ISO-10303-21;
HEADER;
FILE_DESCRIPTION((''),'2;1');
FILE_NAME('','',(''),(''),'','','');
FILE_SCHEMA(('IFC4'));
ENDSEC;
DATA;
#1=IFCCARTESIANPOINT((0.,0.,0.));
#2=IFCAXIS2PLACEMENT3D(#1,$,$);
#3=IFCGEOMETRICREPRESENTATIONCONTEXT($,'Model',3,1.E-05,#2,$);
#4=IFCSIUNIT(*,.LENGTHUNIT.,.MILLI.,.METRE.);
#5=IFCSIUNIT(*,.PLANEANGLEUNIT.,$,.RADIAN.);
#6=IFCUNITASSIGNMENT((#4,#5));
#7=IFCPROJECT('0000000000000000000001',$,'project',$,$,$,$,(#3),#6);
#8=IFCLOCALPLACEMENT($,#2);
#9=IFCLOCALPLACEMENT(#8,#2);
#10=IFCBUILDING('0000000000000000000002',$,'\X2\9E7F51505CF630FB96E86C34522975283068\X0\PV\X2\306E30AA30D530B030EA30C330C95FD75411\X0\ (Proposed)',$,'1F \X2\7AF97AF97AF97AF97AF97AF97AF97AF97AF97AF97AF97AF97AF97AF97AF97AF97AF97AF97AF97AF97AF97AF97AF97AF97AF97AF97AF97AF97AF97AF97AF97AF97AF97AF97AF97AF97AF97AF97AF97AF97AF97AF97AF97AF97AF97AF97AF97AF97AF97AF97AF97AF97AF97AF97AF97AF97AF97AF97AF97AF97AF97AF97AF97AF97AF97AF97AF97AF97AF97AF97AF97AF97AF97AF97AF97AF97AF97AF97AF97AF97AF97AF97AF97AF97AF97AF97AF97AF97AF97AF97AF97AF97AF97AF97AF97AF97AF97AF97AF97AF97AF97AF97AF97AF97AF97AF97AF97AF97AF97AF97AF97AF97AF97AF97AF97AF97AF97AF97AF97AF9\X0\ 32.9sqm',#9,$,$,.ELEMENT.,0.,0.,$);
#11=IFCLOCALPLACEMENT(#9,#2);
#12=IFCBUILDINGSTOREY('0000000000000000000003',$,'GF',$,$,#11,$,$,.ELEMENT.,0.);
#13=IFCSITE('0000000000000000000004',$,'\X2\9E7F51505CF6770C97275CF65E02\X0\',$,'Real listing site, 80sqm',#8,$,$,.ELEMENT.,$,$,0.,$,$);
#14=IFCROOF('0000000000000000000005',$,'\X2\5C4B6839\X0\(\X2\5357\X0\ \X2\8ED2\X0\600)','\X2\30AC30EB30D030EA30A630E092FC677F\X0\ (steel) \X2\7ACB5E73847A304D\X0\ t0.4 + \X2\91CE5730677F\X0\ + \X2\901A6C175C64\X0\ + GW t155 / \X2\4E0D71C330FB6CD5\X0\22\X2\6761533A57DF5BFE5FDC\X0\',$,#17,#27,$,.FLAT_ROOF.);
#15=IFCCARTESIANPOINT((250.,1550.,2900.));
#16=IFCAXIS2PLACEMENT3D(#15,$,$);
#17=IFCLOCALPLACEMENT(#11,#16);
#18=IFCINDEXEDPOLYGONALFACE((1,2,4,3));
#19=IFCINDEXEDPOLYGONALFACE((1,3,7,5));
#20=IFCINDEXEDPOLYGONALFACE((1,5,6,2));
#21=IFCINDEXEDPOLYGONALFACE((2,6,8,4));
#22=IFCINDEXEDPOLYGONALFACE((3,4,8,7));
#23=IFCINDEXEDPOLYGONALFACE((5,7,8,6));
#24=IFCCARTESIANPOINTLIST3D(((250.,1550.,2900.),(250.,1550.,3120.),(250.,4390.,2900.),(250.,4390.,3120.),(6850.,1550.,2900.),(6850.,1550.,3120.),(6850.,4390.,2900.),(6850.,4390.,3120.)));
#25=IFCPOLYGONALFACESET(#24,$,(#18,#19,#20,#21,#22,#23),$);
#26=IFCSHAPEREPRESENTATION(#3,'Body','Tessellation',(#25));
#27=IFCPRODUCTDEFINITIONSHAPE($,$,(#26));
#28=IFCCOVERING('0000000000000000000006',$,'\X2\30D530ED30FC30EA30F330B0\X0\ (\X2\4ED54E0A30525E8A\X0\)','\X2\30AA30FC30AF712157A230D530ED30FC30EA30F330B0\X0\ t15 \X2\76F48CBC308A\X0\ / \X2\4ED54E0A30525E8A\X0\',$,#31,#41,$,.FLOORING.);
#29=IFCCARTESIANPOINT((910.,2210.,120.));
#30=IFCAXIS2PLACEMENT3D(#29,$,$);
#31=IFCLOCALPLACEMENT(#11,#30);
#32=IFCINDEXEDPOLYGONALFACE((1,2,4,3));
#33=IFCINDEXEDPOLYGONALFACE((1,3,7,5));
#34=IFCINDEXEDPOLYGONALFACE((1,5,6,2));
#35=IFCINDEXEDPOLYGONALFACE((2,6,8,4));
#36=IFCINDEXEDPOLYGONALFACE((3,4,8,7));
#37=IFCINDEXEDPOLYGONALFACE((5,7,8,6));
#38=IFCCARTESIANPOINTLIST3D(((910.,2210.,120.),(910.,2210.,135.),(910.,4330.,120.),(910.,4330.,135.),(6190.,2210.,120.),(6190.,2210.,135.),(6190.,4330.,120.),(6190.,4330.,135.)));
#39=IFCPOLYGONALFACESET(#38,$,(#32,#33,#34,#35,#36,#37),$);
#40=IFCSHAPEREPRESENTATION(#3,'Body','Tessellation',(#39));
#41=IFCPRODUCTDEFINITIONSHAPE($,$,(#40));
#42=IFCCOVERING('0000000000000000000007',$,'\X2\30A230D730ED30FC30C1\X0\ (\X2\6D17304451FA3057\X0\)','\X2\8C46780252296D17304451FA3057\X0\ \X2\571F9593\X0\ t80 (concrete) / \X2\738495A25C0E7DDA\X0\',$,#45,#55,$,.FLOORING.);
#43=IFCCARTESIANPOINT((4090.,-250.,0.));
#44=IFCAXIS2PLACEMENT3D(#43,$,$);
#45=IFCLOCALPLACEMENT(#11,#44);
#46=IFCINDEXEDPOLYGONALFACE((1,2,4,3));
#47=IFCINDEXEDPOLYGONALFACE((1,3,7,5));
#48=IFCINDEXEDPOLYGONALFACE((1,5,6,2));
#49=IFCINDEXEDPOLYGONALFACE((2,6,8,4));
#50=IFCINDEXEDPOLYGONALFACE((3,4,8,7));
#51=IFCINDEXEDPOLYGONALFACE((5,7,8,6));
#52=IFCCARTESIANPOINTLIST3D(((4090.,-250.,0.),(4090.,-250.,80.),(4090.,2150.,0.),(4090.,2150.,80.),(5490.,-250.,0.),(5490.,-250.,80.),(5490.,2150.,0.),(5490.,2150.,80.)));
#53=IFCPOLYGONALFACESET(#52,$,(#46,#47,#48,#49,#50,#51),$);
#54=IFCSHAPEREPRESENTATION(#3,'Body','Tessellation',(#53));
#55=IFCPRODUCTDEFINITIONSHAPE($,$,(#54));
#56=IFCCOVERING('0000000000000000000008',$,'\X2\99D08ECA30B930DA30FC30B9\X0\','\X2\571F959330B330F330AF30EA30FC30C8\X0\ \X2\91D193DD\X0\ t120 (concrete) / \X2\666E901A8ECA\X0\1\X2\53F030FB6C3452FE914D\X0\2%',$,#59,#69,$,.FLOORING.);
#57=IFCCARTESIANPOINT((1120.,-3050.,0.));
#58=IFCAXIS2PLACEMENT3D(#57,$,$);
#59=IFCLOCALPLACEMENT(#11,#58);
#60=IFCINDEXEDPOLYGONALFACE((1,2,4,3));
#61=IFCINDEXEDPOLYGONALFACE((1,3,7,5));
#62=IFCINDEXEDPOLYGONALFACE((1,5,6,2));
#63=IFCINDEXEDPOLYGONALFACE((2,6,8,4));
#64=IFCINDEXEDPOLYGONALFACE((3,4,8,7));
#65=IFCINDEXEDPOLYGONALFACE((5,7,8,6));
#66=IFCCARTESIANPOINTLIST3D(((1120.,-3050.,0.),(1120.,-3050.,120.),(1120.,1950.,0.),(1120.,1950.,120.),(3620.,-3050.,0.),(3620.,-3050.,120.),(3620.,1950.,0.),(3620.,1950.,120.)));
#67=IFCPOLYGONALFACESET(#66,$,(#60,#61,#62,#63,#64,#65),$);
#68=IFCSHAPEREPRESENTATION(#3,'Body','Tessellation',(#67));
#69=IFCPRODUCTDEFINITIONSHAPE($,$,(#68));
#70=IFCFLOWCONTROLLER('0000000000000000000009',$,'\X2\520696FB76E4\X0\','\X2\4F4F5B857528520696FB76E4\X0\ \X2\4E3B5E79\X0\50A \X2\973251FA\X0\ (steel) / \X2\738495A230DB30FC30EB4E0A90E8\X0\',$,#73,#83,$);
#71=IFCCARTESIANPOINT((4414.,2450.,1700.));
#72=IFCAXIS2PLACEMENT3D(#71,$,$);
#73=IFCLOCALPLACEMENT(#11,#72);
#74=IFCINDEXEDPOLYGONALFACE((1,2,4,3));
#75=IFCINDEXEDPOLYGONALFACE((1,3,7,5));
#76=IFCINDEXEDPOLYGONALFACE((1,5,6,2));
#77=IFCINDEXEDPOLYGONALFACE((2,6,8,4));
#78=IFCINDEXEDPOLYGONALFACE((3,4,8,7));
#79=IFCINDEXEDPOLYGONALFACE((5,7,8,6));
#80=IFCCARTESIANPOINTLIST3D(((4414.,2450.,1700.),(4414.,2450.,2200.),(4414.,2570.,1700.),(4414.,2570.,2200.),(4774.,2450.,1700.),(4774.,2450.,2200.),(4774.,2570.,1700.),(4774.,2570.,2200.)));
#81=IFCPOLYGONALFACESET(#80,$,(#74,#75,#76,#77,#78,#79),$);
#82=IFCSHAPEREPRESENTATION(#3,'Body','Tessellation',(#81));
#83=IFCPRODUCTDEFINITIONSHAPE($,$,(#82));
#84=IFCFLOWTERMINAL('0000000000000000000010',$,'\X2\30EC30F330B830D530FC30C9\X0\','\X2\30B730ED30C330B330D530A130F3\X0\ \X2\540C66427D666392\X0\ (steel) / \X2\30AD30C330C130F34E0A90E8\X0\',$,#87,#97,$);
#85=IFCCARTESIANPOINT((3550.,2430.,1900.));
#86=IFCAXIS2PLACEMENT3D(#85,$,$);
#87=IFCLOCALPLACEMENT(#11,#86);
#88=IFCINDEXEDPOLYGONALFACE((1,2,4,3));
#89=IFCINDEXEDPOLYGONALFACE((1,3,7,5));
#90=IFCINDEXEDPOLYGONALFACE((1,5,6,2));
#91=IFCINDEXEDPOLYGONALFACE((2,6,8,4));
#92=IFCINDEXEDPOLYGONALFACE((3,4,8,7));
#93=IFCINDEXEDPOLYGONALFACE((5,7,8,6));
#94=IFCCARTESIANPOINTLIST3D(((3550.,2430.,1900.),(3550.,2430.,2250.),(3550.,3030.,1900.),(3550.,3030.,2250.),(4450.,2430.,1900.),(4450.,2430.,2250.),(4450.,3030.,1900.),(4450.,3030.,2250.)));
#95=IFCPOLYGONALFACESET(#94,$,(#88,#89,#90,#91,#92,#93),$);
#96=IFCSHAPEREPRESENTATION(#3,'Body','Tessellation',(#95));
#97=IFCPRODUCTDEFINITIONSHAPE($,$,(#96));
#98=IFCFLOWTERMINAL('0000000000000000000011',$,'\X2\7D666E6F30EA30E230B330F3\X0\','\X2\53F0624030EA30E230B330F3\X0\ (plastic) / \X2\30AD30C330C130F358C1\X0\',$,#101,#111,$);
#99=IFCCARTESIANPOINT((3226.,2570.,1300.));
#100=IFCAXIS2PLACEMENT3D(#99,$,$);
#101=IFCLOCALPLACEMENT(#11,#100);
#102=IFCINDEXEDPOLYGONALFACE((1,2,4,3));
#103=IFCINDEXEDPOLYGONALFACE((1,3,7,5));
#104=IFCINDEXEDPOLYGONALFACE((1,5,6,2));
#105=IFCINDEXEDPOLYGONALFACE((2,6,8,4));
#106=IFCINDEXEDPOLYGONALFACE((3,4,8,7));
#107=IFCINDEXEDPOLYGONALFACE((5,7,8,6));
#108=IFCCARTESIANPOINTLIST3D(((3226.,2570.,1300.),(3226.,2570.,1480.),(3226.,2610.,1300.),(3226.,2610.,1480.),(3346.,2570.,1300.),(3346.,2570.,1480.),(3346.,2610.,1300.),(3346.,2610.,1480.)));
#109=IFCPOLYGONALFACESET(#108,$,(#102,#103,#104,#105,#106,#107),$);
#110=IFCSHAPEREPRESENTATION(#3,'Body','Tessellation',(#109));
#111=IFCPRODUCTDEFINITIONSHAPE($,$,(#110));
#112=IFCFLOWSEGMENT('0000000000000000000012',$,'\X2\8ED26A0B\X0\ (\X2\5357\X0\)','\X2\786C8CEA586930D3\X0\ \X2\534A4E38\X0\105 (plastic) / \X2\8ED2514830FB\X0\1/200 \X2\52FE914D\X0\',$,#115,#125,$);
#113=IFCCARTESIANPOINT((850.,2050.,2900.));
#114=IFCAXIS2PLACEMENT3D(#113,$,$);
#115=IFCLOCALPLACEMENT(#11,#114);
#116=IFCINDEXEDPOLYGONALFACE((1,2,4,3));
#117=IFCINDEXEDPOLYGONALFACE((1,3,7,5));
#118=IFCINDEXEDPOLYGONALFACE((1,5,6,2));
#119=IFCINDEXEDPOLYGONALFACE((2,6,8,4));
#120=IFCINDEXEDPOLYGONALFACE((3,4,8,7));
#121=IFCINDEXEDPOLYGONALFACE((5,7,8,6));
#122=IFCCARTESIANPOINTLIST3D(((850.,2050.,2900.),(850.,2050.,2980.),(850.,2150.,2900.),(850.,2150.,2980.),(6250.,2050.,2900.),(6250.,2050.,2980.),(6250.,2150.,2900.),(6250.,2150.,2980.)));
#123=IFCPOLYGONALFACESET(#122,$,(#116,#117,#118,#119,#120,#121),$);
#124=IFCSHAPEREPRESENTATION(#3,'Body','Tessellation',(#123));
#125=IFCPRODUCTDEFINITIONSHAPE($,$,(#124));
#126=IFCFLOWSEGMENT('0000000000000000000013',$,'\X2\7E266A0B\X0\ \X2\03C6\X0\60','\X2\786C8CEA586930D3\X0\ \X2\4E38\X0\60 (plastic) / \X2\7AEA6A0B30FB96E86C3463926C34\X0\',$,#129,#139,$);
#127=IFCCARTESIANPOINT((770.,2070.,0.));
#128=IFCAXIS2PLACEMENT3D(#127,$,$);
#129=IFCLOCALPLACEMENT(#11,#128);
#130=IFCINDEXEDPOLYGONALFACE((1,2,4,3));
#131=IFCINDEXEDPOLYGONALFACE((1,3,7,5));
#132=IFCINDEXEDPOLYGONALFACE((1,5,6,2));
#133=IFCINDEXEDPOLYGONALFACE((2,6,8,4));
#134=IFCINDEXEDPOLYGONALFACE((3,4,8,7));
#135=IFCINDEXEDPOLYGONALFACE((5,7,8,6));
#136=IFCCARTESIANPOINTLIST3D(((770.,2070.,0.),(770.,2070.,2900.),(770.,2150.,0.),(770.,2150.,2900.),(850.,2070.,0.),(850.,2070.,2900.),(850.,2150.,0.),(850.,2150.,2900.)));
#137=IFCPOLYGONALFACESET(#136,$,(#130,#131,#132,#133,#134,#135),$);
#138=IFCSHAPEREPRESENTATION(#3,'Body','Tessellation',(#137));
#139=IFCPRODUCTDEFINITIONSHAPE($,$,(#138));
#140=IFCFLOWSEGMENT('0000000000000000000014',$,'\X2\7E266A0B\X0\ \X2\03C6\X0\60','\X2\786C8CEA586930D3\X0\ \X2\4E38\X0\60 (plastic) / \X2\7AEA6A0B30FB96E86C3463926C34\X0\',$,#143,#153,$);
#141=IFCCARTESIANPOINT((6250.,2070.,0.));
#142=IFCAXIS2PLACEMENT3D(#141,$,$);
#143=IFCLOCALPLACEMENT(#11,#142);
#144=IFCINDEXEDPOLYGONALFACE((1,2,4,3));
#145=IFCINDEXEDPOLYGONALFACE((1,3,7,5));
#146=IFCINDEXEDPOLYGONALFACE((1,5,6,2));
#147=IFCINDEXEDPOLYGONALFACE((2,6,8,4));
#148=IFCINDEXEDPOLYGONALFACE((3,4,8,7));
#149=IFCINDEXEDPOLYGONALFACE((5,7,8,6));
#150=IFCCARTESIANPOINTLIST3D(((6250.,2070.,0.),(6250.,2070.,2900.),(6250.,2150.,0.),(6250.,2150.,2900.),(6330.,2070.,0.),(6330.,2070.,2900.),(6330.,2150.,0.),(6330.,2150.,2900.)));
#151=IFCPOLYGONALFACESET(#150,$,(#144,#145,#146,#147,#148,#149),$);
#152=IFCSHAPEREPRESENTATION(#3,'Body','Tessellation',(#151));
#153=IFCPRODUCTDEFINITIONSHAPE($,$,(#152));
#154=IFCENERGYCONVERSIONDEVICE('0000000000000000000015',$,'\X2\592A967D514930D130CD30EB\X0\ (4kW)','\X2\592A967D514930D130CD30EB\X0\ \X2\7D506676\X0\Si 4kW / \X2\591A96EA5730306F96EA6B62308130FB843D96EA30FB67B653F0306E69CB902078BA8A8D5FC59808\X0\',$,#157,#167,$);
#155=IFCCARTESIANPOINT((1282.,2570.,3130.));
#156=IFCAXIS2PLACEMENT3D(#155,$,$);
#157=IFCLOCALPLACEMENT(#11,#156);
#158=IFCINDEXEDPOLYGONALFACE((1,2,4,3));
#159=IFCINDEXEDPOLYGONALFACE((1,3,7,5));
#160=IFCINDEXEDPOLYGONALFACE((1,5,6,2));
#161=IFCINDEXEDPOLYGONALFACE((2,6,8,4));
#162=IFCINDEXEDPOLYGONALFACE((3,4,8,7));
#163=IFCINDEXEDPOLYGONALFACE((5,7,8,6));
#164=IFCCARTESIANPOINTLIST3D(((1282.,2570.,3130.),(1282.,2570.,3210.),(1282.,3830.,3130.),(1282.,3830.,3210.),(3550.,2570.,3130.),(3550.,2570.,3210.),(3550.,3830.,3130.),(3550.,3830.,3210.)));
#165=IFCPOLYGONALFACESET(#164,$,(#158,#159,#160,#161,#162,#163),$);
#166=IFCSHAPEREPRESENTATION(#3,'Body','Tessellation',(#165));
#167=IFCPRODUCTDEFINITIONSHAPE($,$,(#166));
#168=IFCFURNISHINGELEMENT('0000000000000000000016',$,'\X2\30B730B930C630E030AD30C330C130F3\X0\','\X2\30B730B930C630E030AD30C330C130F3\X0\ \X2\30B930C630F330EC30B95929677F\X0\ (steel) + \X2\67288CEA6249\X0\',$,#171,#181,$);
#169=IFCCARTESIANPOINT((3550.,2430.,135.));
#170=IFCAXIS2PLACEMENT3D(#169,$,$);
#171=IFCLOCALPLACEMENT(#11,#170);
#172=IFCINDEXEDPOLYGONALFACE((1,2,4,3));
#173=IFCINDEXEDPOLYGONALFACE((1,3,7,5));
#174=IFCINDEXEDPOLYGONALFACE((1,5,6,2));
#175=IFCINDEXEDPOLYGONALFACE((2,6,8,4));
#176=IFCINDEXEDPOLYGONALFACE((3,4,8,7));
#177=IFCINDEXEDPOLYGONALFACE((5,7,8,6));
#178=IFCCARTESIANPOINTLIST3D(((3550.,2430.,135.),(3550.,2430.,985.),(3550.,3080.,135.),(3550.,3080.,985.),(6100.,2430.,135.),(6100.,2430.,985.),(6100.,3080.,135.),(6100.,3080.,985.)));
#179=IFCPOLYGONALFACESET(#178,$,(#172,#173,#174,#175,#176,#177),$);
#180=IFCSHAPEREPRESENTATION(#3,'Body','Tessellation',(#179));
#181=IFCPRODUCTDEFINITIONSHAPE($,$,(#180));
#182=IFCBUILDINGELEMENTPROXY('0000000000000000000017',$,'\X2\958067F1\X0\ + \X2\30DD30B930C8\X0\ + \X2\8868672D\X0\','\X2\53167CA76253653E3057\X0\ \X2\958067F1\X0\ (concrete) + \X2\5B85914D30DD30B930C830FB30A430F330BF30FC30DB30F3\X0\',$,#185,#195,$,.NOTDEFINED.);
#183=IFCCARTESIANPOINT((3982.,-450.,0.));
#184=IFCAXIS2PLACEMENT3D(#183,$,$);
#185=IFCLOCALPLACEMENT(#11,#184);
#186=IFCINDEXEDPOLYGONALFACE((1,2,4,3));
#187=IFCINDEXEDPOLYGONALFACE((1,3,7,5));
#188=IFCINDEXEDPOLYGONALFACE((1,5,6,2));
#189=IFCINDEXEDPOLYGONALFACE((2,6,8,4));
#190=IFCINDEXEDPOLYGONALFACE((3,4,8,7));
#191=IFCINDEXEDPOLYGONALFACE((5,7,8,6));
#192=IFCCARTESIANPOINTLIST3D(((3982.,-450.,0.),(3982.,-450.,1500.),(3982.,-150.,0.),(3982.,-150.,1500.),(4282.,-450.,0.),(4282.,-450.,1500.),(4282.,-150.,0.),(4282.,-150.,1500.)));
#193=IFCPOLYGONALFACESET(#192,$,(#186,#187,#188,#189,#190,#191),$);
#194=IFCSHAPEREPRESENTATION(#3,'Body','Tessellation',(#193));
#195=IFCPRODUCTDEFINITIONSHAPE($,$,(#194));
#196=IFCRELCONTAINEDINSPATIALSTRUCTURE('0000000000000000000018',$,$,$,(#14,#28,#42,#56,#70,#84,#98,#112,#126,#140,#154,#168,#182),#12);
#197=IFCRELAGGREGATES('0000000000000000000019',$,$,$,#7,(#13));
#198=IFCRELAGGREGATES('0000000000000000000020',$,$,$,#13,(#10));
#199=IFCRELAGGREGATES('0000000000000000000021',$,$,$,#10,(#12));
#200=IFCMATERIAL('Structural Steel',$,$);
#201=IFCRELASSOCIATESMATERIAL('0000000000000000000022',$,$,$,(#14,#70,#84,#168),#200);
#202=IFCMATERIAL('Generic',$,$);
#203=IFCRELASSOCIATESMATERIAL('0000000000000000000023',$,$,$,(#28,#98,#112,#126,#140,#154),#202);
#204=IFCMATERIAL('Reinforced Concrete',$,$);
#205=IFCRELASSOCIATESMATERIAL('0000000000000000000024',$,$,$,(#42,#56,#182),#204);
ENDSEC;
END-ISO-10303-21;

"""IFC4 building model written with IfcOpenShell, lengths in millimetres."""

from ifc_helpers import new_model, si_unit, frame, frame_2d, origin, place, context, project, spatial, rectangle, extrude, material, element, save


model = new_model("IFC4")

# Units and contexts
model_context = context("Model", 3, precision=1e-05, world=origin())
ifc_project = project(units=[si_unit("LENGTHUNIT", "METRE", prefix="MILLI"), si_unit("PLANEANGLEUNIT", "RADIAN")], contexts=[model_context])

# Site, building, storey
site_placement = place(None, origin())
site = spatial("IfcSite", under=ifc_project, at=site_placement, Name="鹿児島県霧島市", ObjectType="Real listing site, 80sqm", CompositionType="ELEMENT", RefElevation=0.0)
building_placement = place(site_placement, origin())
building = spatial("IfcBuilding", under=site, at=building_placement, Name="鹿児島・雨水利用とPVのオフグリッド志向 (Proposed)", ObjectType="1F 竹竹竹竹竹竹竹竹竹竹竹竹竹竹竹竹竹竹竹竹竹竹竹竹竹竹竹竹竹竹竹竹竹竹竹竹竹竹竹竹竹竹竹竹竹竹竹竹竹竹竹竹竹竹竹竹竹竹竹竹竹竹竹竹竹竹竹竹竹竹竹竹竹竹竹竹竹竹竹竹竹竹竹竹竹竹竹竹竹竹竹竹竹竹竹竹竹竹竹竹竹竹竹竹竹竹竹竹竹竹竹竹竹竹竹竹竹竹竹竹 32.9sqm", CompositionType="ELEMENT", ElevationOfRefHeight=0.0, ElevationOfTerrain=0.0)
storey_placement = place(building_placement, origin())
storey = spatial("IfcBuildingStorey", under=building, at=storey_placement, Name="GF", CompositionType="ELEMENT", Elevation=0.0)

# Shared definitions
ifc_material_1 = material(Name="Reinforced Concrete")

# Roof
ifc_material_2 = material(Name="Structural Steel")
roof_placement = place(storey_placement, frame((250.0, 1550.0, 2900.0)))
element("IfcRoof", 1, at=roof_placement, inside=storey, material=ifc_material_2, Name="屋根(南 軒600)", Description="ガルバリウム鋼板 (steel) 立平葺き t0.4 + 野地板 + 通気層 + GW t155 / 不燃・法22条区域対応", PredefinedType="FLAT_ROOF", context=model_context, shape_type="SweptSolid", body=[
    extrude(rectangle(XDim=6600.0, YDim=2840.0, at=frame_2d((3300.0, 1420.0))), frame((250.0, 1550.0, 2900.0)), (0.0, 0.0, 1.0), 220.0),
])

# Coverings
ifc_material_3 = material(Name="Generic")
covering_1_placement = place(storey_placement, frame((910.0, 2210.0, 120.0)))
element("IfcCovering", 2, at=covering_1_placement, inside=storey, material=ifc_material_3, Name="フローリング (仕上げ床)", Description="オーク無垢フローリング t15 直貼り / 仕上げ床", PredefinedType="FLOORING", context=model_context, shape_type="SweptSolid", body=[
    extrude(rectangle(XDim=5280.0, YDim=2120.0, at=frame_2d((2640.0, 1060.0))), frame((910.0, 2210.0, 120.0)), (0.0, 0.0, 1.0), 15.0),
])
covering_2_placement = place(storey_placement, frame((4090.0, -250.0, 0.0)))
element("IfcCovering", 3, at=covering_2_placement, inside=storey, material=ifc_material_1, Name="アプローチ (洗い出し)", Description="豆砂利洗い出し 土間 t80 (concrete) / 玄関導線", PredefinedType="FLOORING", context=model_context, shape_type="SweptSolid", body=[
    extrude(rectangle(XDim=1400.0, YDim=2400.0, at=frame_2d((700.0, 1200.0))), frame((4090.0, -250.0, 0.0)), (0.0, 0.0, 1.0), 80.0),
])
covering_3_placement = place(storey_placement, frame((1120.0, -3050.0, 0.0)))
element("IfcCovering", 4, at=covering_3_placement, inside=storey, material=ifc_material_1, Name="駐車スペース", Description="土間コンクリート 金鏝 t120 (concrete) / 普通車1台・水勾配2%", PredefinedType="FLOORING", context=model_context, shape_type="SweptSolid", body=[
    extrude(rectangle(XDim=2500.0, YDim=5000.0, at=frame_2d((1250.0, 2500.0))), frame((1120.0, -3050.0, 0.0)), (0.0, 0.0, 1.0), 120.0),
])

# Flow controller
flow_controller_placement = place(storey_placement, frame((4414.0, 2450.0, 1700.0)))
element("IfcFlowController", 5, at=flow_controller_placement, inside=storey, material=ifc_material_2, Name="分電盤", Description="住宅用分電盤 主幹50A 露出 (steel) / 玄関ホール上部", context=model_context, shape_type="SweptSolid", body=[
    extrude(rectangle(XDim=360.0, YDim=120.0, at=frame_2d((180.0, 60.0))), frame((4414.0, 2450.0, 1700.0)), (0.0, 0.0, 1.0), 500.0),
])

# Flow terminals
flow_terminal_1_placement = place(storey_placement, frame((3550.0, 2430.0, 1900.0)))
element("IfcFlowTerminal", 6, at=flow_terminal_1_placement, inside=storey, material=ifc_material_2, Name="レンジフード", Description="シロッコファン 同時給排 (steel) / キッチン上部", context=model_context, shape_type="SweptSolid", body=[
    extrude(rectangle(XDim=900.0, YDim=600.0, at=frame_2d((450.0, 300.0))), frame((3550.0, 2430.0, 1900.0)), (0.0, 0.0, 1.0), 350.0),
])
flow_terminal_2_placement = place(storey_placement, frame((3226.0, 2570.0, 1300.0)))
element("IfcFlowTerminal", 7, at=flow_terminal_2_placement, inside=storey, material=ifc_material_3, Name="給湯リモコン", Description="台所リモコン (plastic) / キッチン壁", context=model_context, shape_type="SweptSolid", body=[
    extrude(rectangle(XDim=120.0, YDim=40.0, at=frame_2d((60.0, 20.0))), frame((3226.0, 2570.0, 1300.0)), (0.0, 0.0, 1.0), 180.0),
])

# Flow segments
flow_segment_1_placement = place(storey_placement, frame((850.0, 2050.0, 2900.0)))
element("IfcFlowSegment", 8, at=flow_segment_1_placement, inside=storey, material=ifc_material_3, Name="軒樋 (南)", Description="硬質塩ビ 半丸105 (plastic) / 軒先・1/200 勾配", context=model_context, shape_type="SweptSolid", body=[
    extrude(rectangle(XDim=5400.0, YDim=100.0, at=frame_2d((2700.0, 50.0))), frame((850.0, 2050.0, 2900.0)), (0.0, 0.0, 1.0), 80.0),
])
flow_segment_2_placement = place(storey_placement, frame((770.0, 2070.0, 0.0)))
element("IfcFlowSegment", 9, at=flow_segment_2_placement, inside=storey, material=ifc_material_3, Name="縦樋 φ60", Description="硬質塩ビ 丸60 (plastic) / 竪樋・雨水排水", context=model_context, shape_type="SweptSolid", body=[
    extrude(rectangle(XDim=80.0, YDim=80.0, at=frame_2d((40.0, 40.0))), frame((770.0, 2070.0, 0.0)), (0.0, 0.0, 1.0), 2900.0),
])
flow_segment_3_placement = place(storey_placement, frame((6250.0, 2070.0, 0.0)))
element("IfcFlowSegment", 10, at=flow_segment_3_placement, inside=storey, material=ifc_material_3, Name="縦樋 φ60", Description="硬質塩ビ 丸60 (plastic) / 竪樋・雨水排水", context=model_context, shape_type="SweptSolid", body=[
    extrude(rectangle(XDim=80.0, YDim=80.0, at=frame_2d((40.0, 40.0))), frame((6250.0, 2070.0, 0.0)), (0.0, 0.0, 1.0), 2900.0),
])

# Energy conversion device
energy_conversion_device_placement = place(storey_placement, frame((1282.0, 2570.0, 3130.0)))
element("IfcEnergyConversionDevice", 11, at=energy_conversion_device_placement, inside=storey, material=ifc_material_3, Name="太陽光パネル (4kW)", Description="太陽光パネル 結晶Si 4kW / 多雪地は雪止め・落雪・架台の構造確認必須", context=model_context, shape_type="SweptSolid", body=[
    extrude(rectangle(XDim=2268.0, YDim=1260.0, at=frame_2d((1134.0, 630.0))), frame((1282.0, 2570.0, 3130.0)), (0.0, 0.0, 1.0), 80.0),
])

# Furnishing element
furnishing_placement = place(storey_placement, frame((3550.0, 2430.0, 135.0)))
element("IfcFurnishingElement", 12, at=furnishing_placement, inside=storey, material=ifc_material_2, Name="システムキッチン", Description="システムキッチン ステンレス天板 (steel) + 木質扉", context=model_context, shape_type="SweptSolid", body=[
    extrude(rectangle(XDim=2550.0, YDim=650.0, at=frame_2d((1275.0, 325.0))), frame((3550.0, 2430.0, 135.0)), (0.0, 0.0, 1.0), 850.0),
])

# Building element proxy
proxy_placement = place(storey_placement, frame((3982.0, -450.0, 0.0)))
element("IfcBuildingElementProxy", 13, at=proxy_placement, inside=storey, material=ifc_material_1, Name="門柱 + ポスト + 表札", Description="化粧打放し 門柱 (concrete) + 宅配ポスト・インターホン", PredefinedType="NOTDEFINED", context=model_context, shape_type="SweptSolid", body=[
    extrude(rectangle(XDim=300.0, YDim=300.0, at=frame_2d((150.0, 150.0))), frame((3982.0, -450.0, 0.0)), (0.0, 0.0, 1.0), 1500.0),
])

save(model, "model.ifc")
